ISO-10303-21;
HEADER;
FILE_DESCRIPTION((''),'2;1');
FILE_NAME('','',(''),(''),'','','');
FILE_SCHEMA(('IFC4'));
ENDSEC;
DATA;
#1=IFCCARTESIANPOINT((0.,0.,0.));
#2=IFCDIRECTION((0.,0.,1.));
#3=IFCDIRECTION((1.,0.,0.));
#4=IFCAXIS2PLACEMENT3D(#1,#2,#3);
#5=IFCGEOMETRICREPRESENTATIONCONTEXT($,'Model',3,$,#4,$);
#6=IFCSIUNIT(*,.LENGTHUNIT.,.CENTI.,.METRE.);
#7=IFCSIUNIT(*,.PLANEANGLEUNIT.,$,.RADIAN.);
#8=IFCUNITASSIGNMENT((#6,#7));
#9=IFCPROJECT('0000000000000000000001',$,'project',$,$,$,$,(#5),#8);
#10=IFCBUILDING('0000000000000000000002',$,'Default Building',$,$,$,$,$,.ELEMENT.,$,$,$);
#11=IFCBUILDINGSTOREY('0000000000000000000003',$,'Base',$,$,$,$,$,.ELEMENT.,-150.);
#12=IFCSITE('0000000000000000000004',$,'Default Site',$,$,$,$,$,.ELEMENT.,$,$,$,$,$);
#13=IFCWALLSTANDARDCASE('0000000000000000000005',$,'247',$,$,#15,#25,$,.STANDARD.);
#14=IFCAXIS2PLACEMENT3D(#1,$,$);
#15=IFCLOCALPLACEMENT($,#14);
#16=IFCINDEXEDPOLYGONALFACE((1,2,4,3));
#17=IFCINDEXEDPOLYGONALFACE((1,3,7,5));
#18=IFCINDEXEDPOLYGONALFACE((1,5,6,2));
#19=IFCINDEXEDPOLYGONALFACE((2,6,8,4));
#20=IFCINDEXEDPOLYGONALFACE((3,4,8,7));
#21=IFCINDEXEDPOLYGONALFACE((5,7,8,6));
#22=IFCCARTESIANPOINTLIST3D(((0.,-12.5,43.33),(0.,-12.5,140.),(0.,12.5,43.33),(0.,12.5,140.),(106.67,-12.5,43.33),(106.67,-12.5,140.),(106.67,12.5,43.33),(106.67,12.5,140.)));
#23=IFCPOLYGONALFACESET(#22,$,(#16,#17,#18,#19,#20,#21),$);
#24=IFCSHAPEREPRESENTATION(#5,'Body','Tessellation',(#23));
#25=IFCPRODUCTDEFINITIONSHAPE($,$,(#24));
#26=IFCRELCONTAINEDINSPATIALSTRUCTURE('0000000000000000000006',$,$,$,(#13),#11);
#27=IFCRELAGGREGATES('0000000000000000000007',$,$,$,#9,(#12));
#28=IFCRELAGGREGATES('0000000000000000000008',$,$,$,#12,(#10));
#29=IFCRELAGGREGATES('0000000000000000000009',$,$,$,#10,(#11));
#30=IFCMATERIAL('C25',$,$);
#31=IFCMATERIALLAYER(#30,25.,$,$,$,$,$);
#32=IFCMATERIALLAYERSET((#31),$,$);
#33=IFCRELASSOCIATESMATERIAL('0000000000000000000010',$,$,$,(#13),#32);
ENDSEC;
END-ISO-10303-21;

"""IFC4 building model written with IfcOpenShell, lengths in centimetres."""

from ifc_helpers import new_model, si_unit, frame, origin_with_axes, origin_2d_with_axis, place, context, project, spatial, rectangle, extrude, material, layer, layer_set, layer_usage, element, save


model = new_model("IFC4")

# Units and contexts
model_context = context("Model", 3, world=origin_with_axes())
ifc_project = project(units=[si_unit("LENGTHUNIT", "METRE", prefix="CENTI"), si_unit("PLANEANGLEUNIT", "RADIAN")], contexts=[model_context])

# Site, building, storey
site = spatial("IfcSite", under=ifc_project, Name="Default Site", CompositionType="ELEMENT")
building = spatial("IfcBuilding", under=site, Name="Default Building", CompositionType="ELEMENT")
storey = spatial("IfcBuildingStorey", under=building, Name="Base", CompositionType="ELEMENT", Elevation=-150.0)

# Shared definitions
ifc_material = material(Name="C25")

# Wall
ifc_layer_1 = layer(ifc_material, 25.0)
ifc_layer_set_1 = layer_set([ifc_layer_1])
ifc_layer_usage_1 = layer_usage(ifc_layer_set_1, "AXIS2", "POSITIVE", -25.0)
wall_1_placement = place(None, frame((53.33, 0.0, 43.33), z_axis=(0.0, 0.0, 1.0), x_axis=(-1.0, 0.0, 0.0)))
element("IfcWallStandardCase", 1, at=wall_1_placement, inside=storey, material=ifc_layer_usage_1, Name="247", PredefinedType="STANDARD", context=model_context, shape_type="SweptSolid", body=[
    extrude(rectangle(XDim=106.67, YDim=25.0, at=origin_2d_with_axis()), origin_with_axes(), (0.0, 0.0, 1.0), 96.67),
])

save(model, "model.ifc")
